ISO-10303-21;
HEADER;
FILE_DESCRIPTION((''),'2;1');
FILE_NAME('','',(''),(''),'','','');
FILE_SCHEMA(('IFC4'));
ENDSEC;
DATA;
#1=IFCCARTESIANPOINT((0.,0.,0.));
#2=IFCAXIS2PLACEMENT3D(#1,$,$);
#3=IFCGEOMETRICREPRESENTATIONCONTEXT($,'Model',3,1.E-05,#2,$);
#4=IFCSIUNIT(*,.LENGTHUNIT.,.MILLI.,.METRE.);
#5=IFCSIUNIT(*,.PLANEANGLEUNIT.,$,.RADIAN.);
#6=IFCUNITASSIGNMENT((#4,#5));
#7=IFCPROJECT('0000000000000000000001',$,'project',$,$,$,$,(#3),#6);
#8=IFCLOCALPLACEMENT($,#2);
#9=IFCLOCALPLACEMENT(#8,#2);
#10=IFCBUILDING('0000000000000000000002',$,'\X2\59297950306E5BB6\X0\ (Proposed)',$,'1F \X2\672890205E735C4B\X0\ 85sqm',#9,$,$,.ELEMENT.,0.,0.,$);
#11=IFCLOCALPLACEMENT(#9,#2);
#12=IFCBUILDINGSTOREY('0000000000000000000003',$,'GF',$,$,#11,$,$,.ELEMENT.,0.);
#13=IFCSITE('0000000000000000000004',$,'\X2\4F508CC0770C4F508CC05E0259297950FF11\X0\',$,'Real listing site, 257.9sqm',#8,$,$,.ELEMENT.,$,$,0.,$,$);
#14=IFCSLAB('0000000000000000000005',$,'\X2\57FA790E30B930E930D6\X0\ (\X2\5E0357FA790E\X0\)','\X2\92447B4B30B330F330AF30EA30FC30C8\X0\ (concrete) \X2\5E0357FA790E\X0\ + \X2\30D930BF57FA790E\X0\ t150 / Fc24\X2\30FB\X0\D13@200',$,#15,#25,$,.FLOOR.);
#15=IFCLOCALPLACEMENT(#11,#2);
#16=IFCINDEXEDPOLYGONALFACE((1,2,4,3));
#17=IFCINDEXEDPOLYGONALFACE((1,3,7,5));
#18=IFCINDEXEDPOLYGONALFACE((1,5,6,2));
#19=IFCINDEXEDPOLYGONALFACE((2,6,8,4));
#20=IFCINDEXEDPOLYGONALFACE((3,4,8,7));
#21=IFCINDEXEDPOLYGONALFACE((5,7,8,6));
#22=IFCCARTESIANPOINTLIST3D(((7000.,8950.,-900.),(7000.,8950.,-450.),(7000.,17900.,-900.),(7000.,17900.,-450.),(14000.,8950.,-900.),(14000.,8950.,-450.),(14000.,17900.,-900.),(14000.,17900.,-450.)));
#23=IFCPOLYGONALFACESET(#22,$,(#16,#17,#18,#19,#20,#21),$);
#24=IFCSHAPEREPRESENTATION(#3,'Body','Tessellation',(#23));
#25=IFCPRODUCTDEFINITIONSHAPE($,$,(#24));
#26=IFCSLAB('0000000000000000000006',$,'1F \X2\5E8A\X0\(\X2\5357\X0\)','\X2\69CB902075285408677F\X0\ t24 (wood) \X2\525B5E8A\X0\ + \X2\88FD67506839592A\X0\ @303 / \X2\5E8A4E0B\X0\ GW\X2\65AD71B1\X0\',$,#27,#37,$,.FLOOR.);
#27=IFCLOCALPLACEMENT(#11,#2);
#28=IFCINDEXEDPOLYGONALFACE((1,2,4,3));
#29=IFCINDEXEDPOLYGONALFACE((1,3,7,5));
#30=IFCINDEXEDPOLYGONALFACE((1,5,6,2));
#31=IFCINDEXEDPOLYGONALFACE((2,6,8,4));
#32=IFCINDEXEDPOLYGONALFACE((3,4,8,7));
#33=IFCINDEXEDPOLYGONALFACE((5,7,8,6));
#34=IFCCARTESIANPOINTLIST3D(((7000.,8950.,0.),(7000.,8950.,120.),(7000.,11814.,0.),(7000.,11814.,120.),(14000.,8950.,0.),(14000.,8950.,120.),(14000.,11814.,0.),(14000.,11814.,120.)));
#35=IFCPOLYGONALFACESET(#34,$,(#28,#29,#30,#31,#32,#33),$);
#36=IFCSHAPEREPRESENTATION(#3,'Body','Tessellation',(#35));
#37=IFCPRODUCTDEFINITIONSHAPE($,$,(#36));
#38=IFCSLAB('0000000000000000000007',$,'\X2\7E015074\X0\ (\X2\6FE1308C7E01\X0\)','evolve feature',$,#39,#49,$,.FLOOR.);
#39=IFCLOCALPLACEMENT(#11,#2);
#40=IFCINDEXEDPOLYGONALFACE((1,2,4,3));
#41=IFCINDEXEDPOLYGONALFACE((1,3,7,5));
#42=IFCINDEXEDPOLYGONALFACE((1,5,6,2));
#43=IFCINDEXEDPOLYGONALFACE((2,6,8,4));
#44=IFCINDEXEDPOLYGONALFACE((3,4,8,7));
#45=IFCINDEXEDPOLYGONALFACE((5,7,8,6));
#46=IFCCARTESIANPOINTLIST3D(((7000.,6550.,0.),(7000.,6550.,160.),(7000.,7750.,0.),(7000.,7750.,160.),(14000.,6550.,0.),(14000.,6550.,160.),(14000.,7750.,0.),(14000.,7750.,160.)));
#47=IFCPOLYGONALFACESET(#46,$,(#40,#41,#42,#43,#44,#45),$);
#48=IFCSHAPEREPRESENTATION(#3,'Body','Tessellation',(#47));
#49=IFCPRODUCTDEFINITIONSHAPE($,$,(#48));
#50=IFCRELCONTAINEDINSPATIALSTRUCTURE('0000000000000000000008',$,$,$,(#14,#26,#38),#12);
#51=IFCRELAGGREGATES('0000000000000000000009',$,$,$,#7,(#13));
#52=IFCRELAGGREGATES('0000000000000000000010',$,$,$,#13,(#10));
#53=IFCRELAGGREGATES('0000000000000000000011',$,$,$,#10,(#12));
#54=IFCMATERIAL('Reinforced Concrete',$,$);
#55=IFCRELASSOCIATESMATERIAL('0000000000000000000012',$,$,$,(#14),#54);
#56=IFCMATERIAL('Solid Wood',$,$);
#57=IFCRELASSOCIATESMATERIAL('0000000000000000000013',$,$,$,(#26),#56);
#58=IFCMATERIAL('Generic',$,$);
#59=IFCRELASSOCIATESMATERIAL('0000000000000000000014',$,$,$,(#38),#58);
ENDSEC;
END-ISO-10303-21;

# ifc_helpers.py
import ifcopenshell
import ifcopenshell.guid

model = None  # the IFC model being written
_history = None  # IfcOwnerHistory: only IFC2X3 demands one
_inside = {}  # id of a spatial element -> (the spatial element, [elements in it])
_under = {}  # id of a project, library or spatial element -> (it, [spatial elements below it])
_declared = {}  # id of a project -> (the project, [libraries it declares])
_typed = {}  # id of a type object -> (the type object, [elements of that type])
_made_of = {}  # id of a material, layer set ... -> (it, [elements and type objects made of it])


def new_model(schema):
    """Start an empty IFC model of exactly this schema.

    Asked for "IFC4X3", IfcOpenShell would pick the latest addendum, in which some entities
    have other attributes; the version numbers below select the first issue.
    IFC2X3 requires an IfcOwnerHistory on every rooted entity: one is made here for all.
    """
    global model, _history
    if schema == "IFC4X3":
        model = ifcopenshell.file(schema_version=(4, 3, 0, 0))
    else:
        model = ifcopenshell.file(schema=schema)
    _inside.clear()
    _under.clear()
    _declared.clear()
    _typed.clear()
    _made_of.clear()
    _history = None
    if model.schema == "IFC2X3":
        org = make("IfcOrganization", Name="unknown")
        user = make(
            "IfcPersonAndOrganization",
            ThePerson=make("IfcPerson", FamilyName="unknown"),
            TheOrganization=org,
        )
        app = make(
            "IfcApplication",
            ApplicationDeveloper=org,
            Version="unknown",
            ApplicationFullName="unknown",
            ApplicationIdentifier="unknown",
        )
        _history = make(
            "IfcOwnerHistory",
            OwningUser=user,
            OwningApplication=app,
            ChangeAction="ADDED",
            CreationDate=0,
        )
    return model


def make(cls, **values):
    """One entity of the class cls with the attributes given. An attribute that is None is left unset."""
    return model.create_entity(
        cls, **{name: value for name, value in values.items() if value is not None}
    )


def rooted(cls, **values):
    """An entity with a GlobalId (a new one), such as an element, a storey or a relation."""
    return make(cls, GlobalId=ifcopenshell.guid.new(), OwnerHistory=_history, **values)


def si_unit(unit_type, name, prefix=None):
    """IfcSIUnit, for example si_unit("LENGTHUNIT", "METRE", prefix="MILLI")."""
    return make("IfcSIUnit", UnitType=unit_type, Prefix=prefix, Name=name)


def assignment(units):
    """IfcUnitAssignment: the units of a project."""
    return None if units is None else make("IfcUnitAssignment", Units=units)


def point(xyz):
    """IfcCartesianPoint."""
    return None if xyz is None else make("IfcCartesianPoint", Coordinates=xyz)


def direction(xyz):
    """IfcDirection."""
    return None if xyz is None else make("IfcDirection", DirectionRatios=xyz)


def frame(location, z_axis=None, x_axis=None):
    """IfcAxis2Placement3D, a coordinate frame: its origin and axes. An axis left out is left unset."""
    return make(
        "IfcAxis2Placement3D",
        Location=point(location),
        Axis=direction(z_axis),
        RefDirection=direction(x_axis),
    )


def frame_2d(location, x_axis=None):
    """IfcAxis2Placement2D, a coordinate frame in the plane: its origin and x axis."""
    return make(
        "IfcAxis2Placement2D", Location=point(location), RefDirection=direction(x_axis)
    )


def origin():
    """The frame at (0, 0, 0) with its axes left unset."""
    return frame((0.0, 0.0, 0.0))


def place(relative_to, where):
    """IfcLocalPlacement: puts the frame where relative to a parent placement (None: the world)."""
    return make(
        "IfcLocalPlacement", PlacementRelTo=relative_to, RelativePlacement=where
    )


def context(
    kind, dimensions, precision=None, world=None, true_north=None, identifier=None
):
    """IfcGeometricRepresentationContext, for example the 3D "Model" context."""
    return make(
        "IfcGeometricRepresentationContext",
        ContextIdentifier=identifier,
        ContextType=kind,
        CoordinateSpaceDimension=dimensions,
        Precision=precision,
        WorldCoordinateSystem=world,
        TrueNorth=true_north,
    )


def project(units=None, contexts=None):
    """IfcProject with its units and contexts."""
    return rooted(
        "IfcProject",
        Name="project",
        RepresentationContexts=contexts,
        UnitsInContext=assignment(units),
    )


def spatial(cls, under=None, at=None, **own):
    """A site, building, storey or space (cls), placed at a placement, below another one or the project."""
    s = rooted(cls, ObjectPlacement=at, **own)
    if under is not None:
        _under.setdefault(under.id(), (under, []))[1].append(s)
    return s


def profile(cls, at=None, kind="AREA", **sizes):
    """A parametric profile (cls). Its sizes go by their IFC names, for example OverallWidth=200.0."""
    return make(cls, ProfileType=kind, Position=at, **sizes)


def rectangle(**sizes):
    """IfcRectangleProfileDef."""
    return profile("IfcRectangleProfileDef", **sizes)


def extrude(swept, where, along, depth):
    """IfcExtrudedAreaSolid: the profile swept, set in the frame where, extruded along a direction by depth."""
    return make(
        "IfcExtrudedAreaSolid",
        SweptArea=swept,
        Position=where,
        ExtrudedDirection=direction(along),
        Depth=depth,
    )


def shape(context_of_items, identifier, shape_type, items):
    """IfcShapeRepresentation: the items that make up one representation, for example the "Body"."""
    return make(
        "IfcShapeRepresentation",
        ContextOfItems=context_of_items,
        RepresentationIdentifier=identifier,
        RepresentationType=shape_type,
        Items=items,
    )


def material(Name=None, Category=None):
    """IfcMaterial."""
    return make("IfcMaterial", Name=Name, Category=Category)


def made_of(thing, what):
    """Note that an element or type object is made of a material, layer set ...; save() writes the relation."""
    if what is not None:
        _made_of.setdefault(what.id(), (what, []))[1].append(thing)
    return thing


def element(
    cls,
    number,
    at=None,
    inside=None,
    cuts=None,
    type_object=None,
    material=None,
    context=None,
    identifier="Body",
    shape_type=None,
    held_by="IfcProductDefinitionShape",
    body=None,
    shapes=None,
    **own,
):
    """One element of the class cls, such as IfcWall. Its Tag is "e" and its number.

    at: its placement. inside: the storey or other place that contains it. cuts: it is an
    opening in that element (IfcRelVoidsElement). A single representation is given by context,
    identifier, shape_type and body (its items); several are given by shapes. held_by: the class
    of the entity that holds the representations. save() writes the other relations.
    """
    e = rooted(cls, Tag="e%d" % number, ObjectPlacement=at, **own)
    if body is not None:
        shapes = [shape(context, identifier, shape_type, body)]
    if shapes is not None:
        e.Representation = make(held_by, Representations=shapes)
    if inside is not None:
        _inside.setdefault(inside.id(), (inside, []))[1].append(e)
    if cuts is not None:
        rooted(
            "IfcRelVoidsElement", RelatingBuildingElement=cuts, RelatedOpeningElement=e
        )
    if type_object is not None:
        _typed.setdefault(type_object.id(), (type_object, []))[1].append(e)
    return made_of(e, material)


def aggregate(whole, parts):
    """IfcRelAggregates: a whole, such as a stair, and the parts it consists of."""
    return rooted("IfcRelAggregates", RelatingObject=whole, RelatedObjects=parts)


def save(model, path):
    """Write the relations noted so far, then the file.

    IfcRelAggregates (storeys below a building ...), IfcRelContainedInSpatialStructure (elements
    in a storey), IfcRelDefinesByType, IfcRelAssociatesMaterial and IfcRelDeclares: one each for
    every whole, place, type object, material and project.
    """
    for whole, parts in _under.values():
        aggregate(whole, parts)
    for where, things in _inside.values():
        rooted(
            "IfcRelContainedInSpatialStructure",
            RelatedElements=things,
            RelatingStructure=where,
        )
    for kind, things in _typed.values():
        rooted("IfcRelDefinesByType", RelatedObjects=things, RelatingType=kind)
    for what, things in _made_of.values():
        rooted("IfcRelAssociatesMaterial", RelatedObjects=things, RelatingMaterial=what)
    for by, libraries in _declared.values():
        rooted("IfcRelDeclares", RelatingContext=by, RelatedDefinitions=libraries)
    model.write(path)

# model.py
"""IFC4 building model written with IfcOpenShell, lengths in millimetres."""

from ifc_helpers import new_model, si_unit, frame, frame_2d, origin, place, context, project, spatial, rectangle, extrude, material, element, save


model = new_model("IFC4")

# Units and contexts
model_context = context("Model", 3, precision=1e-05, world=origin())
ifc_project = project(units=[si_unit("LENGTHUNIT", "METRE", prefix="MILLI"), si_unit("PLANEANGLEUNIT", "RADIAN")], contexts=[model_context])

# Site, building, storey
site_placement = place(None, origin())
site = spatial("IfcSite", under=ifc_project, at=site_placement, Name="佐賀県佐賀市天祐１", ObjectType="Real listing site, 257.9sqm", CompositionType="ELEMENT", RefElevation=0.0)
building_placement = place(site_placement, origin())
building = spatial("IfcBuilding", under=site, at=building_placement, Name="天祐の家 (Proposed)", ObjectType="1F 木造平屋 85sqm", CompositionType="ELEMENT", ElevationOfRefHeight=0.0, ElevationOfTerrain=0.0)
storey_placement = place(building_placement, origin())
storey = spatial("IfcBuildingStorey", under=building, at=storey_placement, Name="GF", CompositionType="ELEMENT", Elevation=0.0)

# Slabs
ifc_material_1 = material(Name="Reinforced Concrete")
slab_1_placement = place(storey_placement, frame((3500.0, 4475.0, -450.0)))
element("IfcSlab", 1, at=slab_1_placement, inside=storey, material=ifc_material_1, Name="基礎スラブ (布基礎)", Description="鉄筋コンクリート (concrete) 布基礎 + ベタ基礎 t150 / Fc24・D13@200", PredefinedType="FLOOR", context=model_context, shape_type="SweptSolid", body=[
    extrude(rectangle(XDim=7000.0, YDim=8950.0, at=frame_2d((3500.0, 4475.0))), frame((3500.0, 4475.0, -450.0)), (0.0, 0.0, 1.0), 450.0),
])
ifc_material_2 = material(Name="Solid Wood")
slab_2_placement = place(storey_placement, frame((3500.0, 4475.0, 0.0)))
element("IfcSlab", 2, at=slab_2_placement, inside=storey, material=ifc_material_2, Name="1F 床(南)", Description="構造用合板 t24 (wood) 剛床 + 製材根太 @303 / 床下 GW断熱", PredefinedType="FLOOR", context=model_context, shape_type="SweptSolid", body=[
    extrude(rectangle(XDim=7000.0, YDim=2864.0, at=frame_2d((3500.0, 1432.0))), frame((3500.0, 4475.0, 0.0)), (0.0, 0.0, 1.0), 120.0),
])
ifc_material_3 = material(Name="Generic")
slab_3_placement = place(storey_placement, frame((3500.0, 3275.0, 0.0)))
element("IfcSlab", 3, at=slab_3_placement, inside=storey, material=ifc_material_3, Name="縁側 (濡れ縁)", Description="evolve feature", PredefinedType="FLOOR", context=model_context, shape_type="SweptSolid", body=[
    extrude(rectangle(XDim=7000.0, YDim=1200.0, at=frame_2d((3500.0, 600.0))), frame((3500.0, 3275.0, 0.0)), (0.0, 0.0, 1.0), 160.0),
])

save(model, "model.ifc")
